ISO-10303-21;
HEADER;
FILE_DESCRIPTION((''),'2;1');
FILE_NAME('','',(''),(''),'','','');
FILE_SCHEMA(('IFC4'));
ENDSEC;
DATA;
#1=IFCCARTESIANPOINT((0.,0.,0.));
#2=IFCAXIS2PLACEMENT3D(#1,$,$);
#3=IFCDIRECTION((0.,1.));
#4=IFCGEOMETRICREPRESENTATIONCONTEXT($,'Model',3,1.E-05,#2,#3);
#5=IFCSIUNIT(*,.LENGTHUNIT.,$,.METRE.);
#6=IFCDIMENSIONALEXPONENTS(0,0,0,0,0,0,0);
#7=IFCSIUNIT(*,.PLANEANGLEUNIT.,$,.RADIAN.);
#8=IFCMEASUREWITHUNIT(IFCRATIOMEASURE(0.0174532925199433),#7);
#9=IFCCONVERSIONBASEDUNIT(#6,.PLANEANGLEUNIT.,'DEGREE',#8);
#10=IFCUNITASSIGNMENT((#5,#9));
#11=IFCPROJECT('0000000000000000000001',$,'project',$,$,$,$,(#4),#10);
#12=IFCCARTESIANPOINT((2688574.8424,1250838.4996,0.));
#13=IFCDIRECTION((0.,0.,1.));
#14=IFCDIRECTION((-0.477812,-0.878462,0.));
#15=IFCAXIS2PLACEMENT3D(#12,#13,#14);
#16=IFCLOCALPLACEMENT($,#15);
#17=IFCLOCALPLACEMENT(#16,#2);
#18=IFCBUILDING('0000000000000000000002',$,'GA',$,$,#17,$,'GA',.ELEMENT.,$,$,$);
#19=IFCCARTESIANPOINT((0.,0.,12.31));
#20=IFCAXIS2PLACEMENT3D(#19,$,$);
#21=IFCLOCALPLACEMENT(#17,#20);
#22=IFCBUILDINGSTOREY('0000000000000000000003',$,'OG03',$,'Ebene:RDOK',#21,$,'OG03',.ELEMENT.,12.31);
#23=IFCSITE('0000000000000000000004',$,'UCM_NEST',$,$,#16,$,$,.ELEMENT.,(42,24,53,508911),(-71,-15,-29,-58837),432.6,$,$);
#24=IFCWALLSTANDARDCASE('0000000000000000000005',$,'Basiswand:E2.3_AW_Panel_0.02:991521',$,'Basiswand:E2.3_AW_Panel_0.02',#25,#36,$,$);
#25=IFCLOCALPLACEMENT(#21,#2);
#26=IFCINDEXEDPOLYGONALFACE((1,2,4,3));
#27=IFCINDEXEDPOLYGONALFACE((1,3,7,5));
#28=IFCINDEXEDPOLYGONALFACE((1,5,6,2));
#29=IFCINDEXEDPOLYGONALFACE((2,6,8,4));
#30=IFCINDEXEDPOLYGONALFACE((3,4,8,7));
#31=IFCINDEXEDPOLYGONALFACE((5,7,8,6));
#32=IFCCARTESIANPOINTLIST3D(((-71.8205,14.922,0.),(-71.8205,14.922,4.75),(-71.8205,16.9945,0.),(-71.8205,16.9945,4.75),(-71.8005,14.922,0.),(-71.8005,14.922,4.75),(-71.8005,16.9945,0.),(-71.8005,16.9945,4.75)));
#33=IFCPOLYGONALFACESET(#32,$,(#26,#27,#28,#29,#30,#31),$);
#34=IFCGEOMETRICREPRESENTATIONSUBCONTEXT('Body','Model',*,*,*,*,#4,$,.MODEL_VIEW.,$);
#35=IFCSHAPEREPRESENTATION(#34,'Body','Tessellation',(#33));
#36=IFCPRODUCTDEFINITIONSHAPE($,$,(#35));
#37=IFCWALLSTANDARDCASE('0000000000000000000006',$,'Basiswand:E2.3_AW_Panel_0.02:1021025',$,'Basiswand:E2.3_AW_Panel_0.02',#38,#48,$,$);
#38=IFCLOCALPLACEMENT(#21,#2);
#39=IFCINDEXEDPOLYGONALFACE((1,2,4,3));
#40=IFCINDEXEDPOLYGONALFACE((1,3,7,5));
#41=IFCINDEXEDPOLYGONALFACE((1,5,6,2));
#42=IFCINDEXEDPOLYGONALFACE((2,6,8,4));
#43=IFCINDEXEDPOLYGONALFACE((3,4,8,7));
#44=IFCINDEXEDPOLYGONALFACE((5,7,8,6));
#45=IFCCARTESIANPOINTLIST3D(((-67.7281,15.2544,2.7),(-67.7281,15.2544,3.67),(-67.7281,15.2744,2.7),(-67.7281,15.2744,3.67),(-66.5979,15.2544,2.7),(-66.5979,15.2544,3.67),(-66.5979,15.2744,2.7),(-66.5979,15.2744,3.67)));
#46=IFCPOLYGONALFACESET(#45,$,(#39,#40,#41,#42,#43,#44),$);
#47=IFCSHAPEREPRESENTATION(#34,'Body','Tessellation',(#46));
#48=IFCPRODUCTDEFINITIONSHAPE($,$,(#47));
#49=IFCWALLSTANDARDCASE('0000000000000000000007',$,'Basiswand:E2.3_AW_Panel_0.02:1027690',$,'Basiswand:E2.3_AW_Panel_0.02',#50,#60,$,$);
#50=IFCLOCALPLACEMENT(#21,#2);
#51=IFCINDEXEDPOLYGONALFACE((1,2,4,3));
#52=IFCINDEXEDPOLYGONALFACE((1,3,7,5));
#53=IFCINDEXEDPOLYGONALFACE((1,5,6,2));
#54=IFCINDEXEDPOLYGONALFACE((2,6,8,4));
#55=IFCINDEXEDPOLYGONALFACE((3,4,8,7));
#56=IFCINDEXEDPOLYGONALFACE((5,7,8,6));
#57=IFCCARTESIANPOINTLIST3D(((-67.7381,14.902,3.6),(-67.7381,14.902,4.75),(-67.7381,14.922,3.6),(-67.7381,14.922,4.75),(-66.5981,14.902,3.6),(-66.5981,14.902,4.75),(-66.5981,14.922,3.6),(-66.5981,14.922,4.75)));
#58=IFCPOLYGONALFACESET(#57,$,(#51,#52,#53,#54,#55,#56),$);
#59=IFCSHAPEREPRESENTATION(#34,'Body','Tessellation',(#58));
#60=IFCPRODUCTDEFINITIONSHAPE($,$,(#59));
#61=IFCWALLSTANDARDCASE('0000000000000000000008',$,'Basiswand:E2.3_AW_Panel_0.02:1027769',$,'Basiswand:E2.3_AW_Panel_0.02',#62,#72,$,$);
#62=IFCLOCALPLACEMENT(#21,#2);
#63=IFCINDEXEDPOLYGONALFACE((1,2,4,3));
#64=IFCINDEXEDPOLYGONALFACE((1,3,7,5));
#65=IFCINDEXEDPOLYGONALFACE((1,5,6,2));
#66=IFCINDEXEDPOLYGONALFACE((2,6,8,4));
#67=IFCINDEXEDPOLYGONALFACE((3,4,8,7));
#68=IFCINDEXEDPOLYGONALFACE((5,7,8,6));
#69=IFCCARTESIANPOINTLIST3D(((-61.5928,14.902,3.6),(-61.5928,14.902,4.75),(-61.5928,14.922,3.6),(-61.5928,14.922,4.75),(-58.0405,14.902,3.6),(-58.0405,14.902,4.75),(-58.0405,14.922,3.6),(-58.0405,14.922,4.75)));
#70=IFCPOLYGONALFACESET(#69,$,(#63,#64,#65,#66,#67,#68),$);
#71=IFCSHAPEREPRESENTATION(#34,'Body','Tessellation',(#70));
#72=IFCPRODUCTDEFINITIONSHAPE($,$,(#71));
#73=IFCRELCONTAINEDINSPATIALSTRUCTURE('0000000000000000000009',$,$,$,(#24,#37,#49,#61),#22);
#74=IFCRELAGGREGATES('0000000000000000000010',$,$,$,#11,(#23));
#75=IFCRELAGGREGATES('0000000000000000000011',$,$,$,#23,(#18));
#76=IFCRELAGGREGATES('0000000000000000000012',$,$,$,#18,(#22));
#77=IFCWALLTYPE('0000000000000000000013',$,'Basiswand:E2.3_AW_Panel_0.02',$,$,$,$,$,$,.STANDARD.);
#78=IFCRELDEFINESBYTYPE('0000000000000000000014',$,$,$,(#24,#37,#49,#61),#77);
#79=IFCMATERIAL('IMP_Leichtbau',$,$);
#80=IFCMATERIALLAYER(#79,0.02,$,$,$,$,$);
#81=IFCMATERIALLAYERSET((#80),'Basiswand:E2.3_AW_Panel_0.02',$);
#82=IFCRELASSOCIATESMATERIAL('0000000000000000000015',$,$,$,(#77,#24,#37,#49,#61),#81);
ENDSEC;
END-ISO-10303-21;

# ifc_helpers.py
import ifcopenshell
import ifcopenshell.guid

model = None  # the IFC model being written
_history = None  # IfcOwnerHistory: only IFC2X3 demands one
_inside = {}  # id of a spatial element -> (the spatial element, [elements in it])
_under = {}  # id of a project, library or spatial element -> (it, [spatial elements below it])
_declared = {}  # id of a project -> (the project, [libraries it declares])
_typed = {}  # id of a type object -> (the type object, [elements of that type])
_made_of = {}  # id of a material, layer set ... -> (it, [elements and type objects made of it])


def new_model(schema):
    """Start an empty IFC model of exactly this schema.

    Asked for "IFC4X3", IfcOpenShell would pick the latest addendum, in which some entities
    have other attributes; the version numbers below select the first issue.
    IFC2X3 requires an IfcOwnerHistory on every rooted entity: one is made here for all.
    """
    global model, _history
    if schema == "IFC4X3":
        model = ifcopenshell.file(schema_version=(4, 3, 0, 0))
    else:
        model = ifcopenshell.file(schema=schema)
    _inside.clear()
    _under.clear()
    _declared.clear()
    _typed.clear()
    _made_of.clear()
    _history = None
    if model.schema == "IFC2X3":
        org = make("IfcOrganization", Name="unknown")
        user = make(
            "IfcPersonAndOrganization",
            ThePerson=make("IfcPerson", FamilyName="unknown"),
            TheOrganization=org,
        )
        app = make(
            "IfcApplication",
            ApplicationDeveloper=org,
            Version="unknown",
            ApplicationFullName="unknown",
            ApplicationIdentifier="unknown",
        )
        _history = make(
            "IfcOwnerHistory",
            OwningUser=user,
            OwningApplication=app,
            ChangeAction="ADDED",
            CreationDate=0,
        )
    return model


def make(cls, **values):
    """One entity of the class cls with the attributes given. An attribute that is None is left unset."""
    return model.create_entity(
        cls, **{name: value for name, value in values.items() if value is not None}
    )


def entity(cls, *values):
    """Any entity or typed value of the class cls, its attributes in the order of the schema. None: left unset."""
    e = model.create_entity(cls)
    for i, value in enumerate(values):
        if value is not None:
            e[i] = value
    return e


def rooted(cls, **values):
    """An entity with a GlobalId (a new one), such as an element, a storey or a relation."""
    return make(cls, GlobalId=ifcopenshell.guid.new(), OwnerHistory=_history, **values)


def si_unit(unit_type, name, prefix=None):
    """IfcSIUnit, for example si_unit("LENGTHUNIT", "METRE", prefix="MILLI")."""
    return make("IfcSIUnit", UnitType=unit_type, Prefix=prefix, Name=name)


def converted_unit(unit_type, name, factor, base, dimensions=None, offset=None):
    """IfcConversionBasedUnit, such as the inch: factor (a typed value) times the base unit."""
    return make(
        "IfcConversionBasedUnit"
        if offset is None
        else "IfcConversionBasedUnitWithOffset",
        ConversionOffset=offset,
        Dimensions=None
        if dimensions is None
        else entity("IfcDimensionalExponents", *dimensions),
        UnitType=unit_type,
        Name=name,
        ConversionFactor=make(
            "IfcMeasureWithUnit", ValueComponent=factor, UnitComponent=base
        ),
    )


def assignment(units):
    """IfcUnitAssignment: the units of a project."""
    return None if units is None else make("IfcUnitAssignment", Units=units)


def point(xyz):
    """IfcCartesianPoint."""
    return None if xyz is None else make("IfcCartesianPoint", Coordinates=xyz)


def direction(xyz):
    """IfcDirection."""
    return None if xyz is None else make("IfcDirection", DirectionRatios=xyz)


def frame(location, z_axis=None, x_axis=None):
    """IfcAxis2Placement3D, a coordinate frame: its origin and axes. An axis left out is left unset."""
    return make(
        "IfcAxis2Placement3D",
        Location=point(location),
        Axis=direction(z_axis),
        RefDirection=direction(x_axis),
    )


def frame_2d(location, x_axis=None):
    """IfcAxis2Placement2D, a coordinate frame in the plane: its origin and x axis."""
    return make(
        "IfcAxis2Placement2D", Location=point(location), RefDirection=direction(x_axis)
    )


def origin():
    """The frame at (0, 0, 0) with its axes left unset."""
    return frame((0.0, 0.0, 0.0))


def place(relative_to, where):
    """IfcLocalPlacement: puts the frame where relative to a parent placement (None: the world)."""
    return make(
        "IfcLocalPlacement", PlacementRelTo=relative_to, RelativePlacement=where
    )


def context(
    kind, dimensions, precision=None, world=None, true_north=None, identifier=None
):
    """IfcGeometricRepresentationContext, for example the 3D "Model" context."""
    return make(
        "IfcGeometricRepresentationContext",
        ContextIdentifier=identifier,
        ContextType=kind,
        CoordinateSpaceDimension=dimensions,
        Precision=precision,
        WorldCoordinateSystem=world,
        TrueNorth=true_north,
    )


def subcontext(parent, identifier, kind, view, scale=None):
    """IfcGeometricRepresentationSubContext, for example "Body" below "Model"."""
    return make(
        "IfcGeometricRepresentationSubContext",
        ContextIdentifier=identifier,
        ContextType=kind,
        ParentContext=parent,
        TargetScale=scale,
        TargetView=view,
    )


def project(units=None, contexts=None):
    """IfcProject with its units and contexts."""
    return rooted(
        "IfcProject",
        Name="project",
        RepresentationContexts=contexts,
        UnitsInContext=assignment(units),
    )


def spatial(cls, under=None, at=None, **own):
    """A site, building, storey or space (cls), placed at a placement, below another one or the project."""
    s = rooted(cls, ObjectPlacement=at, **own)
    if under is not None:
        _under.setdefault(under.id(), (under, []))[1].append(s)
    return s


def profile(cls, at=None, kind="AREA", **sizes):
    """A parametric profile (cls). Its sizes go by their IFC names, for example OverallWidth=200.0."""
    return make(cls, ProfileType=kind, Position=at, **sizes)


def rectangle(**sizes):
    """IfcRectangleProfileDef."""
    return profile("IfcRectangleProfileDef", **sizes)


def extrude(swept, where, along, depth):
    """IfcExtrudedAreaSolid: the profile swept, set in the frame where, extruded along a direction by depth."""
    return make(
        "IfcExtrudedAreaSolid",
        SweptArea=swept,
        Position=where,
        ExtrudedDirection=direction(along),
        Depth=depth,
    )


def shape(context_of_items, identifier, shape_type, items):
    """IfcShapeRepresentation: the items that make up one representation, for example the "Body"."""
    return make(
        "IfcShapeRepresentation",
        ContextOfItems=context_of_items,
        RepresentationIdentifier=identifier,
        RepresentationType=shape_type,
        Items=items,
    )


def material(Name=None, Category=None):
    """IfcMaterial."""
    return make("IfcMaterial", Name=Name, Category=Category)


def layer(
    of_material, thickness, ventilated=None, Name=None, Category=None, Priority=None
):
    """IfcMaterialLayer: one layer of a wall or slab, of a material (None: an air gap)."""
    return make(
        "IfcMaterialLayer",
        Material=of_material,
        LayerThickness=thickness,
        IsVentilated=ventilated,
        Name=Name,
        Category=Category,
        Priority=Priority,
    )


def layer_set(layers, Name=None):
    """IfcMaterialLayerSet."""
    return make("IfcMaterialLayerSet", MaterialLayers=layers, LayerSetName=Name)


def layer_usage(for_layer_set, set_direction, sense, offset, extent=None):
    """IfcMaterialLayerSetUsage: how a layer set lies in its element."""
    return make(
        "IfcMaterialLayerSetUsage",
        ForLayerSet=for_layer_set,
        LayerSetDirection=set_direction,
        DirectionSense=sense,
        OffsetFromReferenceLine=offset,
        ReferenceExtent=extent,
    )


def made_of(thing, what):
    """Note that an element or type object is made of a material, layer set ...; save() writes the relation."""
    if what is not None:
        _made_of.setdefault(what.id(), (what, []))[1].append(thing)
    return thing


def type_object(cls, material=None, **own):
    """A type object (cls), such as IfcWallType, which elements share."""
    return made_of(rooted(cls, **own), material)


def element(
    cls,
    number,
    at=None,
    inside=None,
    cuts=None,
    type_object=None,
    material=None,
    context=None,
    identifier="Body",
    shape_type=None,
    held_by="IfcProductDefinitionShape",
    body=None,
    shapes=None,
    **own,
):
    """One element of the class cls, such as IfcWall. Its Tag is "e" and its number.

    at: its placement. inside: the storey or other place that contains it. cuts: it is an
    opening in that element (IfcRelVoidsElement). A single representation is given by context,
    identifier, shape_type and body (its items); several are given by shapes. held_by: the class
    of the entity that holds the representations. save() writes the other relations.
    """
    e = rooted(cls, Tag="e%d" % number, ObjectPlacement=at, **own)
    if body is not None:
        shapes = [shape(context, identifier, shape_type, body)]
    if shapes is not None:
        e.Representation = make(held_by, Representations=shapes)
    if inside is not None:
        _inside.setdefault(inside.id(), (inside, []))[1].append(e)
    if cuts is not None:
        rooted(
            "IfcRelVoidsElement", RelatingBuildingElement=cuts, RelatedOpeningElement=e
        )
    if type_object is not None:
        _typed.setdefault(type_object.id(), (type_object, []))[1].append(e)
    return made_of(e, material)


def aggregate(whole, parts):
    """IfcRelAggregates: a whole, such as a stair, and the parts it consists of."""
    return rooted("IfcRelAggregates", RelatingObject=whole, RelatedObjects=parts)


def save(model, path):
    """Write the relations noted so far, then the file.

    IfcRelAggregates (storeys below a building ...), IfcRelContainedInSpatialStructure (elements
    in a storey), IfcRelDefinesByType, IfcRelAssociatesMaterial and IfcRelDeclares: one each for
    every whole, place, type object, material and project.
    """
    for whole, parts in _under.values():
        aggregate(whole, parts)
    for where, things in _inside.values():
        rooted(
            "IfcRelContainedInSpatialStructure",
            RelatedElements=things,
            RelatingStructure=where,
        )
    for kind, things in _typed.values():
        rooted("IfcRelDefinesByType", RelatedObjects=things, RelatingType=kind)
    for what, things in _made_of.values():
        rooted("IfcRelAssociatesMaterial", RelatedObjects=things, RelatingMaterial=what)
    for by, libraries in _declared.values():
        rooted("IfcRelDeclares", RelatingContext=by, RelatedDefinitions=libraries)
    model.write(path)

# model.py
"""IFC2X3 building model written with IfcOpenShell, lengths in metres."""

from ifc_helpers import new_model, entity, si_unit, converted_unit, direction, frame, frame_2d, origin, place, context, subcontext, project, spatial, rectangle, extrude, material, layer, layer_set, layer_usage, type_object, element, save


model = new_model("IFC2X3")

# Units and contexts
model_context = context("Model", 3, precision=1e-05, world=origin(), true_north=direction((0.0, 1.0)))
body_context = subcontext(model_context, "Body", "Model", "MODEL_VIEW")
ifc_project = project(units=[si_unit("LENGTHUNIT", "METRE"), converted_unit("PLANEANGLEUNIT", "DEGREE", entity("IfcRatioMeasure", 0.0174532925199433), si_unit("PLANEANGLEUNIT", "RADIAN"), dimensions=[0, 0, 0, 0, 0, 0, 0])], contexts=[model_context])

# Site, building, storey
site_placement = place(None, frame((2688574.8424, 1250838.4996, 0.0), z_axis=(0.0, 0.0, 1.0), x_axis=(-0.477812, -0.878462, 0.0)))
site = spatial("IfcSite", under=ifc_project, at=site_placement, Name="UCM_NEST", CompositionType="ELEMENT", RefLatitude=(42, 24, 53, 508911), RefLongitude=(-71, -15, -29, -58837), RefElevation=432.6)
building_placement = place(site_placement, origin())
building = spatial("IfcBuilding", under=site, at=building_placement, Name="GA", LongName="GA", CompositionType="ELEMENT")
storey_placement = place(building_placement, frame((0.0, 0.0, 12.31)))
storey = spatial("IfcBuildingStorey", under=building, at=storey_placement, Name="OG03", ObjectType="Ebene:RDOK", LongName="OG03", CompositionType="ELEMENT", Elevation=12.31)

# Walls
ifc_material_1 = material(Name="IMP_Leichtbau")
ifc_layer_1 = layer(ifc_material_1, 0.02)
ifc_layer_set_1 = layer_set([ifc_layer_1], Name="Basiswand:E2.3_AW_Panel_0.02")
wall_type_1 = type_object("IfcWallType", Name="Basiswand:E2.3_AW_Panel_0.02", PredefinedType="STANDARD", material=ifc_layer_set_1)
ifc_layer_usage_1 = layer_usage(ifc_layer_set_1, "AXIS2", "NEGATIVE", 0.01)
wall_1_placement = place(storey_placement, frame((-71.8105, 14.922, 0.0), z_axis=(0.0, 0.0, 1.0), x_axis=(0.0, 1.0, 0.0)))
element("IfcWallStandardCase", 1, at=wall_1_placement, inside=storey, type_object=wall_type_1, material=ifc_layer_usage_1, Name="Basiswand:E2.3_AW_Panel_0.02:991521", ObjectType="Basiswand:E2.3_AW_Panel_0.02", context=body_context, shape_type="SweptSolid", body=[
    extrude(rectangle(XDim=2.0725, YDim=0.02, at=frame_2d((1.0362, 0.0), x_axis=(-1.0, 0.0))), origin(), (0.0, 0.0, 1.0), 4.75),
])
ifc_layer_usage_2 = layer_usage(ifc_layer_set_1, "AXIS2", "NEGATIVE", 0.01)
wall_2_placement = place(storey_placement, frame((-66.5979, 15.2644, 2.7), z_axis=(0.0, 0.0, 1.0), x_axis=(-1.0, 0.0, 0.0)))
element("IfcWallStandardCase", 2, at=wall_2_placement, inside=storey, type_object=wall_type_1, material=ifc_layer_usage_2, Name="Basiswand:E2.3_AW_Panel_0.02:1021025", ObjectType="Basiswand:E2.3_AW_Panel_0.02", context=body_context, shape_type="SweptSolid", body=[
    extrude(rectangle(XDim=1.1302, YDim=0.02, at=frame_2d((0.5651, 0.0), x_axis=(-1.0, 0.0))), origin(), (0.0, 0.0, 1.0), 0.97),
])
ifc_layer_usage_3 = layer_usage(ifc_layer_set_1, "AXIS2", "NEGATIVE", 0.01)
wall_3_placement = place(storey_placement, frame((-67.7381, 14.912, 3.6)))
element("IfcWallStandardCase", 3, at=wall_3_placement, inside=storey, type_object=wall_type_1, material=ifc_layer_usage_3, Name="Basiswand:E2.3_AW_Panel_0.02:1027690", ObjectType="Basiswand:E2.3_AW_Panel_0.02", context=body_context, shape_type="SweptSolid", body=[
    extrude(rectangle(XDim=1.14, YDim=0.02, at=frame_2d((0.57, 0.0), x_axis=(-1.0, 0.0))), origin(), (0.0, 0.0, 1.0), 1.15),
])
ifc_layer_usage_4 = layer_usage(ifc_layer_set_1, "AXIS2", "NEGATIVE", 0.01)
wall_4_placement = place(storey_placement, frame((-61.5928, 14.912, 3.6)))
element("IfcWallStandardCase", 4, at=wall_4_placement, inside=storey, type_object=wall_type_1, material=ifc_layer_usage_4, Name="Basiswand:E2.3_AW_Panel_0.02:1027769", ObjectType="Basiswand:E2.3_AW_Panel_0.02", context=body_context, shape_type="SweptSolid", body=[
    extrude(rectangle(XDim=3.5523, YDim=0.02, at=frame_2d((1.7761, 0.0), x_axis=(-1.0, 0.0))), origin(), (0.0, 0.0, 1.0), 1.15),
])

save(model, "model.ifc")
